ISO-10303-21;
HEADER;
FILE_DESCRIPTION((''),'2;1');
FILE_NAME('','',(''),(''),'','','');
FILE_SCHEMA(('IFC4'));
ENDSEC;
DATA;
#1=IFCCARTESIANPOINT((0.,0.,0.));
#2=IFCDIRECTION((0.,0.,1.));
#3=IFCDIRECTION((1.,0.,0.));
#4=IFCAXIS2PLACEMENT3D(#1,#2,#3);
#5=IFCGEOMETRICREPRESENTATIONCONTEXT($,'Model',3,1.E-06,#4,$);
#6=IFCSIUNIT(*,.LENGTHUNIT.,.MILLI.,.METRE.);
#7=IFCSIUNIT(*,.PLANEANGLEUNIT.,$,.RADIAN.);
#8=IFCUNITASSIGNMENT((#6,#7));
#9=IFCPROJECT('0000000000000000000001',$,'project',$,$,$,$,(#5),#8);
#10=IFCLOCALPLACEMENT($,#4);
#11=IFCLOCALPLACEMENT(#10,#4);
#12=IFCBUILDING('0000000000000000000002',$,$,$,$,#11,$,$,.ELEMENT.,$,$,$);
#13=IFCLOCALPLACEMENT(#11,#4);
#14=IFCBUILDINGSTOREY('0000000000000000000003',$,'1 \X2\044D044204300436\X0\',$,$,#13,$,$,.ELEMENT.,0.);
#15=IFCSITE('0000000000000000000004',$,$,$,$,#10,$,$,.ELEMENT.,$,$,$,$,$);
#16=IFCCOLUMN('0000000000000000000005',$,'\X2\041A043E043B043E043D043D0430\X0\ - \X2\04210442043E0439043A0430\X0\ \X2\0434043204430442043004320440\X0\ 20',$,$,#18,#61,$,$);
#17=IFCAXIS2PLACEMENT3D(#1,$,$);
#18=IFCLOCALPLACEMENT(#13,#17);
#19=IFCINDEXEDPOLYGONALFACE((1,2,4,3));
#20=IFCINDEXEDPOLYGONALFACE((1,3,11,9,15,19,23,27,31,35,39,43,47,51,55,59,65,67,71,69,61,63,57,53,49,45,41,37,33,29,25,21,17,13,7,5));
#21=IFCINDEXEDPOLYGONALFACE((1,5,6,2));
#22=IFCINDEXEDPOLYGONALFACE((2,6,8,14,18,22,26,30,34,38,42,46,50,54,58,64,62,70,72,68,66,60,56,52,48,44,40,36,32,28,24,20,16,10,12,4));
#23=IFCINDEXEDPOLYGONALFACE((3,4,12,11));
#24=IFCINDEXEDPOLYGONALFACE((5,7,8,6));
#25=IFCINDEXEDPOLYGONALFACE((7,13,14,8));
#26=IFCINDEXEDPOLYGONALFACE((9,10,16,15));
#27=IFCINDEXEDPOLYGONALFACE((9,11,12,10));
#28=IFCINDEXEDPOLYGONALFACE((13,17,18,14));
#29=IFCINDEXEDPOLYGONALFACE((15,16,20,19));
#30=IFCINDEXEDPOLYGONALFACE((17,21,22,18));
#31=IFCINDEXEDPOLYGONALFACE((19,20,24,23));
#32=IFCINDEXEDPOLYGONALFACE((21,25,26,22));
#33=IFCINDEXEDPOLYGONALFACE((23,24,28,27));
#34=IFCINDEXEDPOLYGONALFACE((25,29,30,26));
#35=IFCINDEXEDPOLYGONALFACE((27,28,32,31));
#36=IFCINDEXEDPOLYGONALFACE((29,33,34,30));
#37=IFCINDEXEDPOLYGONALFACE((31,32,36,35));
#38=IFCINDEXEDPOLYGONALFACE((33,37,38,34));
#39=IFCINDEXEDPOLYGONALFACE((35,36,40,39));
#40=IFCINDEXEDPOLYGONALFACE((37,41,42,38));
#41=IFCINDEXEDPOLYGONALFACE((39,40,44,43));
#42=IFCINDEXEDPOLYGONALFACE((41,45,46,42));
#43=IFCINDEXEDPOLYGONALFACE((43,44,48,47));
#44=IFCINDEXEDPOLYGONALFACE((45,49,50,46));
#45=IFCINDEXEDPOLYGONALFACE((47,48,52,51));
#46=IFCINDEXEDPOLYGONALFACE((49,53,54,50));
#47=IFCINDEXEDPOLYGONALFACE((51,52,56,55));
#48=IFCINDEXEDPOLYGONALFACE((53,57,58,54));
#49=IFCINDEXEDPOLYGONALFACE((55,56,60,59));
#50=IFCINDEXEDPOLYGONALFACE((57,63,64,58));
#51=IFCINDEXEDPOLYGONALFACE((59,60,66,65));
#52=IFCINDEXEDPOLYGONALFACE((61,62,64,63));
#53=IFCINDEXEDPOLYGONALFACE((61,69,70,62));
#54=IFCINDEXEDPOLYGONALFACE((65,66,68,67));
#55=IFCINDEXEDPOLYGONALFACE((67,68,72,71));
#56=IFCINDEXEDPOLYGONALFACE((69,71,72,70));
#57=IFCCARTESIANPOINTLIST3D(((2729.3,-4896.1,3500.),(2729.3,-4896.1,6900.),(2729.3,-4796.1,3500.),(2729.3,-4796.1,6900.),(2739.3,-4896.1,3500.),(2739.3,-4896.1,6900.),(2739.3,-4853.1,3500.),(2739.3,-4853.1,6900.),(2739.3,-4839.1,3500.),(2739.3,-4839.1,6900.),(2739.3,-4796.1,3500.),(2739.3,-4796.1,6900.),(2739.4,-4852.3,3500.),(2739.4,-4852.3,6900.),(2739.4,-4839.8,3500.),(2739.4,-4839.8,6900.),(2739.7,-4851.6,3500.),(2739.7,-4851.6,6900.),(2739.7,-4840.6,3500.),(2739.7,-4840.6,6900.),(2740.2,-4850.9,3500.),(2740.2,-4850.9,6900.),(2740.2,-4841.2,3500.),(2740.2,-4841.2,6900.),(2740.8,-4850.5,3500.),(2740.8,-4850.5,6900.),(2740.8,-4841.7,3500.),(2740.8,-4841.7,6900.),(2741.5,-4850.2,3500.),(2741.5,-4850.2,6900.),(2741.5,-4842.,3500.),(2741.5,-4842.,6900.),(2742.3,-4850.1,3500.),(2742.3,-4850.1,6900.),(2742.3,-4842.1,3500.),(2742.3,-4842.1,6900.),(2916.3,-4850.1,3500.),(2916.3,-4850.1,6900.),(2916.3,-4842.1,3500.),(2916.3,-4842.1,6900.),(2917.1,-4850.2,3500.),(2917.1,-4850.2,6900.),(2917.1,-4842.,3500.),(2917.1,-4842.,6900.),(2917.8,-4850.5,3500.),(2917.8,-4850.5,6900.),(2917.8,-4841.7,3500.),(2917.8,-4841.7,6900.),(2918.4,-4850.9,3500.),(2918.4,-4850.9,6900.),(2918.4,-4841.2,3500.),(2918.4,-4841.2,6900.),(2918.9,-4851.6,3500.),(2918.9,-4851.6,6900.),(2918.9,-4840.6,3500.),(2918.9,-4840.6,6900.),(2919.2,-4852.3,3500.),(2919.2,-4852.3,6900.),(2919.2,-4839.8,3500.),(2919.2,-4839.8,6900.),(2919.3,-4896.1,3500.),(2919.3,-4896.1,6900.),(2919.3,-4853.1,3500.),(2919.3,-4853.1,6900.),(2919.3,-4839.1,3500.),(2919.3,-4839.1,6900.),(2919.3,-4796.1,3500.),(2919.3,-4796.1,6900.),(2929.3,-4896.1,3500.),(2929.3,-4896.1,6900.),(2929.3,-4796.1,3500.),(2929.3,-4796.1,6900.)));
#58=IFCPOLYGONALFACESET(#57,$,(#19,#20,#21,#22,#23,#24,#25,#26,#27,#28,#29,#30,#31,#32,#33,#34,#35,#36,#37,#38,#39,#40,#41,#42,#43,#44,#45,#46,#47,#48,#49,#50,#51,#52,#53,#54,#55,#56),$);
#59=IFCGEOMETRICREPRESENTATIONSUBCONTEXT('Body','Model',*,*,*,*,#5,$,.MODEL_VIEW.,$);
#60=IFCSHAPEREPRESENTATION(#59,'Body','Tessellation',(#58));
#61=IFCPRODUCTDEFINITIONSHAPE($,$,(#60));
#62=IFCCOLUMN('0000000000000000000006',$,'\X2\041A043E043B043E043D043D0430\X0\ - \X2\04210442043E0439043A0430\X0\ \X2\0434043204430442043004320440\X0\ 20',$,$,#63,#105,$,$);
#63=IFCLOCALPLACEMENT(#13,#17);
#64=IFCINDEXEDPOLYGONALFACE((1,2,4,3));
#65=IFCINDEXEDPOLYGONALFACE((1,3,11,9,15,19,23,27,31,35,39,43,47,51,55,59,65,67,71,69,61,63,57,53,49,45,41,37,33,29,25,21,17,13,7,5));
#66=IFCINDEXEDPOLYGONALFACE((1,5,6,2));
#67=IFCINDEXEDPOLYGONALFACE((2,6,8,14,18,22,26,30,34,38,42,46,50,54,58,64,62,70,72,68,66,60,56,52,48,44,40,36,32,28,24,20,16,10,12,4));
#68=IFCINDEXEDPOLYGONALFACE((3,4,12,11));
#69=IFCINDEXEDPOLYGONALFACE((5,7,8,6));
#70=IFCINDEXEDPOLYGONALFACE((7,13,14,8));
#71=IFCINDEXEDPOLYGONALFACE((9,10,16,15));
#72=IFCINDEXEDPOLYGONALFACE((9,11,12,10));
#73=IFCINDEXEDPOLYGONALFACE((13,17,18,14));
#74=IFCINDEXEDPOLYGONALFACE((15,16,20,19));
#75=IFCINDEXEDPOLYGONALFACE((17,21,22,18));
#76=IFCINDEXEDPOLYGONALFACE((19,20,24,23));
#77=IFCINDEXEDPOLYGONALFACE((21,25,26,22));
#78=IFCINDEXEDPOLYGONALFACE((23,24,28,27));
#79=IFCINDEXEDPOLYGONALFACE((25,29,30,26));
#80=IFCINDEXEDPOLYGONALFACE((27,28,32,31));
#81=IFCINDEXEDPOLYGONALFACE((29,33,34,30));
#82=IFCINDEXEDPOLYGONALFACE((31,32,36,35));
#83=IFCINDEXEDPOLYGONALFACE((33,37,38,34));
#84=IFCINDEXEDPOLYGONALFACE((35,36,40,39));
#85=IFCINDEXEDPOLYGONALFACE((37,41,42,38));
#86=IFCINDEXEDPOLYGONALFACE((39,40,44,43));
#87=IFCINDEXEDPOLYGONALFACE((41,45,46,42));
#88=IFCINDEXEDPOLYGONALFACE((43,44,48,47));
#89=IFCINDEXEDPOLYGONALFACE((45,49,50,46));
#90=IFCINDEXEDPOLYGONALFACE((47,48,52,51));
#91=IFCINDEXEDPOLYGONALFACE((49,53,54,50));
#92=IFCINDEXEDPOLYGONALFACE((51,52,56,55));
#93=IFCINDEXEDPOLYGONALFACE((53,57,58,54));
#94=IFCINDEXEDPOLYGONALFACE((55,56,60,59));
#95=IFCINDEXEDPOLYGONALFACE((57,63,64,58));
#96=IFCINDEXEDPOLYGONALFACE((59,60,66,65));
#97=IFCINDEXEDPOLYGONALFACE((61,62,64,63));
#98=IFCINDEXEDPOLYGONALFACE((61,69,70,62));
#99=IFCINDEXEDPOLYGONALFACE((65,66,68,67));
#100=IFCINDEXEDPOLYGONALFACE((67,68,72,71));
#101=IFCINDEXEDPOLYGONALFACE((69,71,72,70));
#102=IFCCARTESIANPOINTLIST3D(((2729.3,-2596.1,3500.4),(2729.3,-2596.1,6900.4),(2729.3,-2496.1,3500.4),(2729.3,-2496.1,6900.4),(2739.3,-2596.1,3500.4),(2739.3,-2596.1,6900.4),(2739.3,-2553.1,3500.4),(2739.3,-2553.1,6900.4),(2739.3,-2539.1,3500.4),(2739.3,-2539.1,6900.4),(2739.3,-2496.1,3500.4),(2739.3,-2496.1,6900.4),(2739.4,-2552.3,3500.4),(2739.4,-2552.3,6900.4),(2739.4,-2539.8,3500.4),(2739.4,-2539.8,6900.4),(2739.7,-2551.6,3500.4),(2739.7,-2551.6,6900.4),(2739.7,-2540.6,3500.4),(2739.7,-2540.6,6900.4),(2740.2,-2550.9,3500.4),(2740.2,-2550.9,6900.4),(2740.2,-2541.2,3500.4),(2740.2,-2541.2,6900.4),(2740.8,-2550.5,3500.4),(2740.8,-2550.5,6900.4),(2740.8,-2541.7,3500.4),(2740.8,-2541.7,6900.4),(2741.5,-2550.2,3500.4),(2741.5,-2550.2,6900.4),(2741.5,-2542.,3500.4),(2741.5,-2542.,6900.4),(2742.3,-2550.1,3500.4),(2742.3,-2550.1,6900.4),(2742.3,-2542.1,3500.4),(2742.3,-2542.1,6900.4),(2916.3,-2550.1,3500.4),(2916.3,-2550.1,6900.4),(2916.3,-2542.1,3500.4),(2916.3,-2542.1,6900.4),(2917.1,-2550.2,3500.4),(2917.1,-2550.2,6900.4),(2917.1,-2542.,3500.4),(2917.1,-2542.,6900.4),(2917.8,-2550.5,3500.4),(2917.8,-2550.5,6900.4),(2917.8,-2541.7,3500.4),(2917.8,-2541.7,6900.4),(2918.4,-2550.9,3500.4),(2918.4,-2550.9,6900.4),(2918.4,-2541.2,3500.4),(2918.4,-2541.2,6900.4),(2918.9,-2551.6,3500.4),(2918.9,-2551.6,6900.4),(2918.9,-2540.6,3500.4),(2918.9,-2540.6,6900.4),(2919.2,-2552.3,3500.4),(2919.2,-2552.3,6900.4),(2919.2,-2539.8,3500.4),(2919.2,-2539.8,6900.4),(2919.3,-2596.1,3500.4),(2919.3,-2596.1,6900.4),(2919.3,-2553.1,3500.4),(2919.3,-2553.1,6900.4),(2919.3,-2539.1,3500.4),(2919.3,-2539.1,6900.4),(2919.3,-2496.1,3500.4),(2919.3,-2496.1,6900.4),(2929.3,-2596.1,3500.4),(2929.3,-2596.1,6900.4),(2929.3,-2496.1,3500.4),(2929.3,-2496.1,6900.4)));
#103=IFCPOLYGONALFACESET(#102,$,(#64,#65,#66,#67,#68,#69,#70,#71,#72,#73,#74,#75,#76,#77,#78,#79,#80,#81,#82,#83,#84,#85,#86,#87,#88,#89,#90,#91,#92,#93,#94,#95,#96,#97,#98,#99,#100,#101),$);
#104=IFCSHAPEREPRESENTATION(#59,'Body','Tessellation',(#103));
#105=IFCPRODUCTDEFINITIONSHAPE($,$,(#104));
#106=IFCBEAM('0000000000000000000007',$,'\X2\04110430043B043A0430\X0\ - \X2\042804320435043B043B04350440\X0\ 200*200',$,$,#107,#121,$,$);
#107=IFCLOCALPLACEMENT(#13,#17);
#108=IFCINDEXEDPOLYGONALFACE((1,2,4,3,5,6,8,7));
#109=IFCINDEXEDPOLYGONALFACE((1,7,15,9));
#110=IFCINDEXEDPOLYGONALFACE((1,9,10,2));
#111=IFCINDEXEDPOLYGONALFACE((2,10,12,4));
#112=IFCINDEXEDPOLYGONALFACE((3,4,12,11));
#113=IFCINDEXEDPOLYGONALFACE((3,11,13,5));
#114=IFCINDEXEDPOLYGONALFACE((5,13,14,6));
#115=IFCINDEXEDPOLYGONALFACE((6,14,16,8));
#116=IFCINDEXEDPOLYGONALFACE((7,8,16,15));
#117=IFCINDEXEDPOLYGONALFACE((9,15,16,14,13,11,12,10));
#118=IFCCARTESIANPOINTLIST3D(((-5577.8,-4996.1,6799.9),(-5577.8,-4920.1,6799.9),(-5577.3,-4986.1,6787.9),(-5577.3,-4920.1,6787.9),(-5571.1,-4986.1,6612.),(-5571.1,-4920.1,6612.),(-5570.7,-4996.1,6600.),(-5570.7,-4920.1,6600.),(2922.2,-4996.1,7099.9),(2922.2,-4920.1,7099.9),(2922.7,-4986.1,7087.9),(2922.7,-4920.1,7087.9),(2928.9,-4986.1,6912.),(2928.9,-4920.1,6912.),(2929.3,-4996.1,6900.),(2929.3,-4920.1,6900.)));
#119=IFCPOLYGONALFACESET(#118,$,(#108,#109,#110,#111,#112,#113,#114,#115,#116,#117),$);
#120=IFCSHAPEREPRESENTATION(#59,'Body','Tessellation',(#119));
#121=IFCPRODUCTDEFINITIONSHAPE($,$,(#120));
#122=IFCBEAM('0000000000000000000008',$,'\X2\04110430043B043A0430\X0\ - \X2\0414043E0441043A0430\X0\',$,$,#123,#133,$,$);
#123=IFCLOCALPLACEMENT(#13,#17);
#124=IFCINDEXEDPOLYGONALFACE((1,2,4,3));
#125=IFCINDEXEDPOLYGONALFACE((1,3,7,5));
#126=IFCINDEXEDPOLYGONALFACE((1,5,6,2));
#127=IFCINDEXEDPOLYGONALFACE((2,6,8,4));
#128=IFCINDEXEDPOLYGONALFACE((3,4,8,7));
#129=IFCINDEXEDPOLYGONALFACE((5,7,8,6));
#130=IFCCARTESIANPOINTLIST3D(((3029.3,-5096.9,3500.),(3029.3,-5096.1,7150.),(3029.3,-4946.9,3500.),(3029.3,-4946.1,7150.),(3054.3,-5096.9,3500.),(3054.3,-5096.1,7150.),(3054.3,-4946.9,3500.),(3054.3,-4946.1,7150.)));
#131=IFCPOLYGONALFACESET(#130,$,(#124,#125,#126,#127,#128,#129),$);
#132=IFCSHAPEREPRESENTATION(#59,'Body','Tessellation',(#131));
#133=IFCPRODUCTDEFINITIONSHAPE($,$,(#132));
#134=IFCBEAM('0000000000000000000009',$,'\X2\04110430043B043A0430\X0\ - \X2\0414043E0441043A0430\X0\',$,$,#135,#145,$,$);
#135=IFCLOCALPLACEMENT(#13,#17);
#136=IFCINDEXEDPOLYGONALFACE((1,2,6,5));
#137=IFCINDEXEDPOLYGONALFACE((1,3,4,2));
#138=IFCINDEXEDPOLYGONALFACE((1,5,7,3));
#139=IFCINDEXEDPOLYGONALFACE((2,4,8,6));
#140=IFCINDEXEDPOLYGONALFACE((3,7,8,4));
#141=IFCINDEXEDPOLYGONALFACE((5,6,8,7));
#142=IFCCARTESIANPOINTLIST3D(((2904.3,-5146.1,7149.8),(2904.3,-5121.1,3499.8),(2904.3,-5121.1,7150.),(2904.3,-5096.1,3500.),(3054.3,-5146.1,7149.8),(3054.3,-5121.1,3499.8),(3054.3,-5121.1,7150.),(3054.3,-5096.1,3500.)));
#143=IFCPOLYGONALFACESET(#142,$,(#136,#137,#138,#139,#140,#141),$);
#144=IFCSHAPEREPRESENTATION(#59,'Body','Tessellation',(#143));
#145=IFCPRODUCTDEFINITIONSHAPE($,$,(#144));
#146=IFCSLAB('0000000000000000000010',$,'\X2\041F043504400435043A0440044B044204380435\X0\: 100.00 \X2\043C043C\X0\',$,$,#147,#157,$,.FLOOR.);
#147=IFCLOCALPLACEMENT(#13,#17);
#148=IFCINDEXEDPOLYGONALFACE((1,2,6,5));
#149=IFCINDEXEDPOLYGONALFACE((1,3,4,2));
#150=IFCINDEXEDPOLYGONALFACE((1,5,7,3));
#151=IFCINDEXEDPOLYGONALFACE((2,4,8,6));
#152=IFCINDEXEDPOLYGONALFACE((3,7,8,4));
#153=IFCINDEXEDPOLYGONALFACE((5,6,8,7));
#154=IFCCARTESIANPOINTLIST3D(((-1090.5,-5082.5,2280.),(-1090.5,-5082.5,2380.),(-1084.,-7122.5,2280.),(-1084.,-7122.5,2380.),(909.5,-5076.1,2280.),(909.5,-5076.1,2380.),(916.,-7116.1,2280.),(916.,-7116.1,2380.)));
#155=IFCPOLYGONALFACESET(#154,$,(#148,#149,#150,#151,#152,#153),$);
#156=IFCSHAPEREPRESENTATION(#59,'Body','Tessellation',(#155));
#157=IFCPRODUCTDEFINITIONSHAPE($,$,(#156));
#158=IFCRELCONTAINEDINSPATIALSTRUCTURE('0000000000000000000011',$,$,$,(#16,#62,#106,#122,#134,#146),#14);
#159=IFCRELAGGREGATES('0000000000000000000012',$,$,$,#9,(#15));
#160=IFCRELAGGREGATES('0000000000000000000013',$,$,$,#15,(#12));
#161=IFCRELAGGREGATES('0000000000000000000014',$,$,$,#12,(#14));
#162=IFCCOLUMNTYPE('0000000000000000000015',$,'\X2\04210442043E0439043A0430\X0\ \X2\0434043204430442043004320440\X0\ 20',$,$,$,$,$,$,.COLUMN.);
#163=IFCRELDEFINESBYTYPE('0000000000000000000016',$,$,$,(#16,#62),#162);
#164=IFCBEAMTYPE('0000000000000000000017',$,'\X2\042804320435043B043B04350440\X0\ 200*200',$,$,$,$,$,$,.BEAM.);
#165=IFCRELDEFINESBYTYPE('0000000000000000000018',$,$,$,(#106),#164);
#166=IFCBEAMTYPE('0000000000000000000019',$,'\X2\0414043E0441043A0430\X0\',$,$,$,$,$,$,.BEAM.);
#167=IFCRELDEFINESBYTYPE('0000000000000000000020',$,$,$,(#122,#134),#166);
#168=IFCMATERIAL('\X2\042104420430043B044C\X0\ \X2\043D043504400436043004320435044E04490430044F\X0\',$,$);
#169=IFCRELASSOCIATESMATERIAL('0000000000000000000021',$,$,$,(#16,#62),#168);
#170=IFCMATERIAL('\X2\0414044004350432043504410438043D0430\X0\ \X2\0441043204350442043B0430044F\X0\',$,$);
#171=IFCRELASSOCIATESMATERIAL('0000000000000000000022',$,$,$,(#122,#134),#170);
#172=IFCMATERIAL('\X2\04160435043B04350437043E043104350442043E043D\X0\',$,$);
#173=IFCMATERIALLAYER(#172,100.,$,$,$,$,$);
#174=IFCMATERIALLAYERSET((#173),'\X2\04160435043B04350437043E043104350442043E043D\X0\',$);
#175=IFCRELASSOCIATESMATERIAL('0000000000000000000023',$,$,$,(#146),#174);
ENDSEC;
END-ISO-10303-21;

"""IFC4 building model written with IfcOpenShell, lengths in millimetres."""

from ifc_helpers import new_model, si_unit, frame, origin_with_axes, place, context, subcontext, project, spatial, line, arc, indexed_curve, outline, extrude, source, transform, mapped, material, layer, layer_set, layer_usage, type_object, element, save


model = new_model("IFC4")

# Units and contexts
model_context = context("Model", 3, precision=1e-06, world=origin_with_axes())
body_context = subcontext(model_context, "Body", "Model", "MODEL_VIEW")
ifc_project = project(units=[si_unit("LENGTHUNIT", "METRE", prefix="MILLI"), si_unit("PLANEANGLEUNIT", "RADIAN")], contexts=[model_context])

# Site, building, storey
site_placement = place(None, origin_with_axes())
site = spatial("IfcSite", under=ifc_project, at=site_placement, CompositionType="ELEMENT")
building_placement = place(site_placement, origin_with_axes())
building = spatial("IfcBuilding", under=site, at=building_placement, CompositionType="ELEMENT")
storey_placement = place(building_placement, origin_with_axes())
storey = spatial("IfcBuildingStorey", under=building, at=storey_placement, Name="1 этаж", CompositionType="ELEMENT", Elevation=0.0)

# Columns
ifc_material_1 = material(Name="Сталь нержавеющая")
column_type = type_object("IfcColumnType", Name="Стойка двутавр 20", PredefinedType="COLUMN")
shared_shape_1 = source(origin_with_axes(), body_context, "Body", "SweptSolid", [
    extrude(outline(indexed_curve([(-50.0, -100.0), (50.0, -100.0), (50.0, -90.0), (7.0, -90.0), (4.9, -89.1), (4.0, -87.0), (4.0, 87.0), (4.9, 89.1), (7.0, 90.0), (50.0, 90.0), (50.0, 100.0), (-50.0, 100.0), (-50.0, 90.0), (-7.0, 90.0), (-4.9, 89.1), (-4.0, 87.0), (-4.0, -87.0), (-4.9, -89.1), (-7.0, -90.0), (-50.0, -90.0)], segments=[line(1, 2), line(2, 3), line(3, 4), arc(4, 5, 6), line(6, 7), arc(7, 8, 9), line(9, 10), line(10, 11), line(11, 12), line(12, 13), line(13, 14), arc(14, 15, 16), line(16, 17), arc(17, 18, 19), line(19, 20), line(20, 1)])), origin_with_axes(), (0.0, 0.0, 1.0), 3400.0),
])
for number, where, z_axis, x_axis, name in (
    (1, (2829.3, -4846.1, 3500.0), (0.0, 0.0, 1.0), (0.0, -1.0, 0.0), "Колонна - Стойка двутавр 20"),
    (2, (2829.3, -2546.1, 3500.4), (0.0, 0.0, 1.0), (0.0, -1.0, 0.0), "Колонна - Стойка двутавр 20"),
):
    element("IfcColumn", number, at=place(storey_placement, frame(where, z_axis=z_axis, x_axis=x_axis)), inside=storey, type_object=column_type, material=ifc_material_1, Name=name, context=body_context, shape_type="MappedRepresentation", body=[
        mapped(shared_shape_1, transform((0.0, 0.0, 0.0), x_axis=(1.0, 0.0, 0.0), y_axis=(0.0, 1.0, 0.0), z_axis=(0.0, 0.0, 1.0), scale=1.0)),
    ])

# Beams
beam_type_1 = type_object("IfcBeamType", Name="Швеллер 200*200", PredefinedType="BEAM")
shared_shape_2 = source(origin_with_axes(), body_context, "Body", "SweptSolid", [
    extrude(outline(indexed_curve([(0.0, 0.0), (76.0, 0.0), (76.0, 12.0), (10.0, 12.0), (10.0, 188.0), (76.0, 188.0), (76.0, 200.0), (0.0, 200.0)], segments=[line(1, 2), line(2, 3), line(3, 4), line(4, 5), line(5, 6), line(6, 7), line(7, 8), line(8, 1)])), origin_with_axes(), (0.0, 0.0, -1.0), 8505.3),
])
beam_1_placement = place(storey_placement, frame((2929.3, -4996.1, 6900.0), z_axis=(0.999378, 0.0, 0.035272), x_axis=(0.0, 1.0, 0.0)))
element("IfcBeam", 3, at=beam_1_placement, inside=storey, type_object=beam_type_1, Name="Балка - Швеллер 200*200", context=body_context, shape_type="MappedRepresentation", body=[
    mapped(shared_shape_2, transform((0.0, 0.0, 0.0), x_axis=(1.0, 0.0, 0.0), y_axis=(0.0, 1.0, 0.0), z_axis=(0.0, 0.0, 1.0), scale=1.0)),
])
ifc_material_2 = material(Name="Древесина светлая")
beam_type_2 = type_object("IfcBeamType", Name="Доска", PredefinedType="BEAM")
shared_shape_3 = source(origin_with_axes(), body_context, "Body", "SweptSolid", [
    extrude(outline(indexed_curve([(0.0, 0.0), (150.0, 0.0), (150.0, 25.0), (0.0, 25.0)], segments=[line(1, 2), line(2, 3), line(3, 4), line(4, 1)])), origin_with_axes(), (0.0, 0.0, -1.0), 3650.0),
])
beam_2_placement = place(storey_placement, frame((3029.3, -5096.9, 3500.0), z_axis=(0.0, -0.000217, -1.0), x_axis=(0.0, 1.0, -0.000217)))
element("IfcBeam", 4, at=beam_2_placement, inside=storey, type_object=beam_type_2, material=ifc_material_2, Name="Балка - Доска", context=body_context, shape_type="MappedRepresentation", body=[
    mapped(shared_shape_3, transform((0.0, 0.0, 0.0), x_axis=(1.0, 0.0, 0.0), y_axis=(0.0, 1.0, 0.0), z_axis=(0.0, 0.0, 1.0), scale=1.0)),
])
shared_shape_4 = source(origin_with_axes(), body_context, "Body", "SweptSolid", [
    extrude(outline(indexed_curve([(0.0, 0.0), (150.0, 0.0), (150.0, 25.0), (0.0, 25.0)], segments=[line(1, 2), line(2, 3), line(3, 4), line(4, 1)])), origin_with_axes(), (0.0, 0.0, -1.0), 3650.1),
])
beam_3_placement = place(storey_placement, frame((3054.3, -5121.1, 7150.0), z_axis=(0.0, -0.006849, 0.999977), x_axis=(-1.0, 0.0, 0.0)))
element("IfcBeam", 5, at=beam_3_placement, inside=storey, type_object=beam_type_2, material=ifc_material_2, Name="Балка - Доска", context=body_context, shape_type="MappedRepresentation", body=[
    mapped(shared_shape_4, transform((0.0, 0.0, 0.0), x_axis=(1.0, 0.0, 0.0), y_axis=(0.0, 1.0, 0.0), z_axis=(0.0, 0.0, 1.0), scale=1.0)),
])

# Slab
ifc_material_3 = material(Name="Железобетон")
ifc_layer_1 = layer(ifc_material_3, 100.0)
ifc_layer_set_1 = layer_set([ifc_layer_1], Name="Железобетон")
ifc_layer_usage_1 = layer_usage(ifc_layer_set_1, "AXIS3", "NEGATIVE", -100.0)
slab_placement = place(storey_placement, frame((909.5, -5076.1, 2280.0), z_axis=(0.0, 0.0, 1.0), x_axis=(0.003183, -0.999995, 0.0)))
element("IfcSlab", 6, at=slab_placement, inside=storey, material=ifc_layer_usage_1, Name="Перекрытие: 100.00 мм", PredefinedType="FLOOR", context=body_context, shape_type="SweptSolid", body=[
    extrude(outline(indexed_curve([(0.0, 0.0), (2040.0, 0.0), (2040.0, -2000.0), (0.0, -2000.0)], segments=[line(1, 2), line(2, 3), line(3, 4), line(4, 1)])), origin_with_axes(), (0.0, 0.0, 1.0), 100.0),
])

save(model, "model.ifc")
